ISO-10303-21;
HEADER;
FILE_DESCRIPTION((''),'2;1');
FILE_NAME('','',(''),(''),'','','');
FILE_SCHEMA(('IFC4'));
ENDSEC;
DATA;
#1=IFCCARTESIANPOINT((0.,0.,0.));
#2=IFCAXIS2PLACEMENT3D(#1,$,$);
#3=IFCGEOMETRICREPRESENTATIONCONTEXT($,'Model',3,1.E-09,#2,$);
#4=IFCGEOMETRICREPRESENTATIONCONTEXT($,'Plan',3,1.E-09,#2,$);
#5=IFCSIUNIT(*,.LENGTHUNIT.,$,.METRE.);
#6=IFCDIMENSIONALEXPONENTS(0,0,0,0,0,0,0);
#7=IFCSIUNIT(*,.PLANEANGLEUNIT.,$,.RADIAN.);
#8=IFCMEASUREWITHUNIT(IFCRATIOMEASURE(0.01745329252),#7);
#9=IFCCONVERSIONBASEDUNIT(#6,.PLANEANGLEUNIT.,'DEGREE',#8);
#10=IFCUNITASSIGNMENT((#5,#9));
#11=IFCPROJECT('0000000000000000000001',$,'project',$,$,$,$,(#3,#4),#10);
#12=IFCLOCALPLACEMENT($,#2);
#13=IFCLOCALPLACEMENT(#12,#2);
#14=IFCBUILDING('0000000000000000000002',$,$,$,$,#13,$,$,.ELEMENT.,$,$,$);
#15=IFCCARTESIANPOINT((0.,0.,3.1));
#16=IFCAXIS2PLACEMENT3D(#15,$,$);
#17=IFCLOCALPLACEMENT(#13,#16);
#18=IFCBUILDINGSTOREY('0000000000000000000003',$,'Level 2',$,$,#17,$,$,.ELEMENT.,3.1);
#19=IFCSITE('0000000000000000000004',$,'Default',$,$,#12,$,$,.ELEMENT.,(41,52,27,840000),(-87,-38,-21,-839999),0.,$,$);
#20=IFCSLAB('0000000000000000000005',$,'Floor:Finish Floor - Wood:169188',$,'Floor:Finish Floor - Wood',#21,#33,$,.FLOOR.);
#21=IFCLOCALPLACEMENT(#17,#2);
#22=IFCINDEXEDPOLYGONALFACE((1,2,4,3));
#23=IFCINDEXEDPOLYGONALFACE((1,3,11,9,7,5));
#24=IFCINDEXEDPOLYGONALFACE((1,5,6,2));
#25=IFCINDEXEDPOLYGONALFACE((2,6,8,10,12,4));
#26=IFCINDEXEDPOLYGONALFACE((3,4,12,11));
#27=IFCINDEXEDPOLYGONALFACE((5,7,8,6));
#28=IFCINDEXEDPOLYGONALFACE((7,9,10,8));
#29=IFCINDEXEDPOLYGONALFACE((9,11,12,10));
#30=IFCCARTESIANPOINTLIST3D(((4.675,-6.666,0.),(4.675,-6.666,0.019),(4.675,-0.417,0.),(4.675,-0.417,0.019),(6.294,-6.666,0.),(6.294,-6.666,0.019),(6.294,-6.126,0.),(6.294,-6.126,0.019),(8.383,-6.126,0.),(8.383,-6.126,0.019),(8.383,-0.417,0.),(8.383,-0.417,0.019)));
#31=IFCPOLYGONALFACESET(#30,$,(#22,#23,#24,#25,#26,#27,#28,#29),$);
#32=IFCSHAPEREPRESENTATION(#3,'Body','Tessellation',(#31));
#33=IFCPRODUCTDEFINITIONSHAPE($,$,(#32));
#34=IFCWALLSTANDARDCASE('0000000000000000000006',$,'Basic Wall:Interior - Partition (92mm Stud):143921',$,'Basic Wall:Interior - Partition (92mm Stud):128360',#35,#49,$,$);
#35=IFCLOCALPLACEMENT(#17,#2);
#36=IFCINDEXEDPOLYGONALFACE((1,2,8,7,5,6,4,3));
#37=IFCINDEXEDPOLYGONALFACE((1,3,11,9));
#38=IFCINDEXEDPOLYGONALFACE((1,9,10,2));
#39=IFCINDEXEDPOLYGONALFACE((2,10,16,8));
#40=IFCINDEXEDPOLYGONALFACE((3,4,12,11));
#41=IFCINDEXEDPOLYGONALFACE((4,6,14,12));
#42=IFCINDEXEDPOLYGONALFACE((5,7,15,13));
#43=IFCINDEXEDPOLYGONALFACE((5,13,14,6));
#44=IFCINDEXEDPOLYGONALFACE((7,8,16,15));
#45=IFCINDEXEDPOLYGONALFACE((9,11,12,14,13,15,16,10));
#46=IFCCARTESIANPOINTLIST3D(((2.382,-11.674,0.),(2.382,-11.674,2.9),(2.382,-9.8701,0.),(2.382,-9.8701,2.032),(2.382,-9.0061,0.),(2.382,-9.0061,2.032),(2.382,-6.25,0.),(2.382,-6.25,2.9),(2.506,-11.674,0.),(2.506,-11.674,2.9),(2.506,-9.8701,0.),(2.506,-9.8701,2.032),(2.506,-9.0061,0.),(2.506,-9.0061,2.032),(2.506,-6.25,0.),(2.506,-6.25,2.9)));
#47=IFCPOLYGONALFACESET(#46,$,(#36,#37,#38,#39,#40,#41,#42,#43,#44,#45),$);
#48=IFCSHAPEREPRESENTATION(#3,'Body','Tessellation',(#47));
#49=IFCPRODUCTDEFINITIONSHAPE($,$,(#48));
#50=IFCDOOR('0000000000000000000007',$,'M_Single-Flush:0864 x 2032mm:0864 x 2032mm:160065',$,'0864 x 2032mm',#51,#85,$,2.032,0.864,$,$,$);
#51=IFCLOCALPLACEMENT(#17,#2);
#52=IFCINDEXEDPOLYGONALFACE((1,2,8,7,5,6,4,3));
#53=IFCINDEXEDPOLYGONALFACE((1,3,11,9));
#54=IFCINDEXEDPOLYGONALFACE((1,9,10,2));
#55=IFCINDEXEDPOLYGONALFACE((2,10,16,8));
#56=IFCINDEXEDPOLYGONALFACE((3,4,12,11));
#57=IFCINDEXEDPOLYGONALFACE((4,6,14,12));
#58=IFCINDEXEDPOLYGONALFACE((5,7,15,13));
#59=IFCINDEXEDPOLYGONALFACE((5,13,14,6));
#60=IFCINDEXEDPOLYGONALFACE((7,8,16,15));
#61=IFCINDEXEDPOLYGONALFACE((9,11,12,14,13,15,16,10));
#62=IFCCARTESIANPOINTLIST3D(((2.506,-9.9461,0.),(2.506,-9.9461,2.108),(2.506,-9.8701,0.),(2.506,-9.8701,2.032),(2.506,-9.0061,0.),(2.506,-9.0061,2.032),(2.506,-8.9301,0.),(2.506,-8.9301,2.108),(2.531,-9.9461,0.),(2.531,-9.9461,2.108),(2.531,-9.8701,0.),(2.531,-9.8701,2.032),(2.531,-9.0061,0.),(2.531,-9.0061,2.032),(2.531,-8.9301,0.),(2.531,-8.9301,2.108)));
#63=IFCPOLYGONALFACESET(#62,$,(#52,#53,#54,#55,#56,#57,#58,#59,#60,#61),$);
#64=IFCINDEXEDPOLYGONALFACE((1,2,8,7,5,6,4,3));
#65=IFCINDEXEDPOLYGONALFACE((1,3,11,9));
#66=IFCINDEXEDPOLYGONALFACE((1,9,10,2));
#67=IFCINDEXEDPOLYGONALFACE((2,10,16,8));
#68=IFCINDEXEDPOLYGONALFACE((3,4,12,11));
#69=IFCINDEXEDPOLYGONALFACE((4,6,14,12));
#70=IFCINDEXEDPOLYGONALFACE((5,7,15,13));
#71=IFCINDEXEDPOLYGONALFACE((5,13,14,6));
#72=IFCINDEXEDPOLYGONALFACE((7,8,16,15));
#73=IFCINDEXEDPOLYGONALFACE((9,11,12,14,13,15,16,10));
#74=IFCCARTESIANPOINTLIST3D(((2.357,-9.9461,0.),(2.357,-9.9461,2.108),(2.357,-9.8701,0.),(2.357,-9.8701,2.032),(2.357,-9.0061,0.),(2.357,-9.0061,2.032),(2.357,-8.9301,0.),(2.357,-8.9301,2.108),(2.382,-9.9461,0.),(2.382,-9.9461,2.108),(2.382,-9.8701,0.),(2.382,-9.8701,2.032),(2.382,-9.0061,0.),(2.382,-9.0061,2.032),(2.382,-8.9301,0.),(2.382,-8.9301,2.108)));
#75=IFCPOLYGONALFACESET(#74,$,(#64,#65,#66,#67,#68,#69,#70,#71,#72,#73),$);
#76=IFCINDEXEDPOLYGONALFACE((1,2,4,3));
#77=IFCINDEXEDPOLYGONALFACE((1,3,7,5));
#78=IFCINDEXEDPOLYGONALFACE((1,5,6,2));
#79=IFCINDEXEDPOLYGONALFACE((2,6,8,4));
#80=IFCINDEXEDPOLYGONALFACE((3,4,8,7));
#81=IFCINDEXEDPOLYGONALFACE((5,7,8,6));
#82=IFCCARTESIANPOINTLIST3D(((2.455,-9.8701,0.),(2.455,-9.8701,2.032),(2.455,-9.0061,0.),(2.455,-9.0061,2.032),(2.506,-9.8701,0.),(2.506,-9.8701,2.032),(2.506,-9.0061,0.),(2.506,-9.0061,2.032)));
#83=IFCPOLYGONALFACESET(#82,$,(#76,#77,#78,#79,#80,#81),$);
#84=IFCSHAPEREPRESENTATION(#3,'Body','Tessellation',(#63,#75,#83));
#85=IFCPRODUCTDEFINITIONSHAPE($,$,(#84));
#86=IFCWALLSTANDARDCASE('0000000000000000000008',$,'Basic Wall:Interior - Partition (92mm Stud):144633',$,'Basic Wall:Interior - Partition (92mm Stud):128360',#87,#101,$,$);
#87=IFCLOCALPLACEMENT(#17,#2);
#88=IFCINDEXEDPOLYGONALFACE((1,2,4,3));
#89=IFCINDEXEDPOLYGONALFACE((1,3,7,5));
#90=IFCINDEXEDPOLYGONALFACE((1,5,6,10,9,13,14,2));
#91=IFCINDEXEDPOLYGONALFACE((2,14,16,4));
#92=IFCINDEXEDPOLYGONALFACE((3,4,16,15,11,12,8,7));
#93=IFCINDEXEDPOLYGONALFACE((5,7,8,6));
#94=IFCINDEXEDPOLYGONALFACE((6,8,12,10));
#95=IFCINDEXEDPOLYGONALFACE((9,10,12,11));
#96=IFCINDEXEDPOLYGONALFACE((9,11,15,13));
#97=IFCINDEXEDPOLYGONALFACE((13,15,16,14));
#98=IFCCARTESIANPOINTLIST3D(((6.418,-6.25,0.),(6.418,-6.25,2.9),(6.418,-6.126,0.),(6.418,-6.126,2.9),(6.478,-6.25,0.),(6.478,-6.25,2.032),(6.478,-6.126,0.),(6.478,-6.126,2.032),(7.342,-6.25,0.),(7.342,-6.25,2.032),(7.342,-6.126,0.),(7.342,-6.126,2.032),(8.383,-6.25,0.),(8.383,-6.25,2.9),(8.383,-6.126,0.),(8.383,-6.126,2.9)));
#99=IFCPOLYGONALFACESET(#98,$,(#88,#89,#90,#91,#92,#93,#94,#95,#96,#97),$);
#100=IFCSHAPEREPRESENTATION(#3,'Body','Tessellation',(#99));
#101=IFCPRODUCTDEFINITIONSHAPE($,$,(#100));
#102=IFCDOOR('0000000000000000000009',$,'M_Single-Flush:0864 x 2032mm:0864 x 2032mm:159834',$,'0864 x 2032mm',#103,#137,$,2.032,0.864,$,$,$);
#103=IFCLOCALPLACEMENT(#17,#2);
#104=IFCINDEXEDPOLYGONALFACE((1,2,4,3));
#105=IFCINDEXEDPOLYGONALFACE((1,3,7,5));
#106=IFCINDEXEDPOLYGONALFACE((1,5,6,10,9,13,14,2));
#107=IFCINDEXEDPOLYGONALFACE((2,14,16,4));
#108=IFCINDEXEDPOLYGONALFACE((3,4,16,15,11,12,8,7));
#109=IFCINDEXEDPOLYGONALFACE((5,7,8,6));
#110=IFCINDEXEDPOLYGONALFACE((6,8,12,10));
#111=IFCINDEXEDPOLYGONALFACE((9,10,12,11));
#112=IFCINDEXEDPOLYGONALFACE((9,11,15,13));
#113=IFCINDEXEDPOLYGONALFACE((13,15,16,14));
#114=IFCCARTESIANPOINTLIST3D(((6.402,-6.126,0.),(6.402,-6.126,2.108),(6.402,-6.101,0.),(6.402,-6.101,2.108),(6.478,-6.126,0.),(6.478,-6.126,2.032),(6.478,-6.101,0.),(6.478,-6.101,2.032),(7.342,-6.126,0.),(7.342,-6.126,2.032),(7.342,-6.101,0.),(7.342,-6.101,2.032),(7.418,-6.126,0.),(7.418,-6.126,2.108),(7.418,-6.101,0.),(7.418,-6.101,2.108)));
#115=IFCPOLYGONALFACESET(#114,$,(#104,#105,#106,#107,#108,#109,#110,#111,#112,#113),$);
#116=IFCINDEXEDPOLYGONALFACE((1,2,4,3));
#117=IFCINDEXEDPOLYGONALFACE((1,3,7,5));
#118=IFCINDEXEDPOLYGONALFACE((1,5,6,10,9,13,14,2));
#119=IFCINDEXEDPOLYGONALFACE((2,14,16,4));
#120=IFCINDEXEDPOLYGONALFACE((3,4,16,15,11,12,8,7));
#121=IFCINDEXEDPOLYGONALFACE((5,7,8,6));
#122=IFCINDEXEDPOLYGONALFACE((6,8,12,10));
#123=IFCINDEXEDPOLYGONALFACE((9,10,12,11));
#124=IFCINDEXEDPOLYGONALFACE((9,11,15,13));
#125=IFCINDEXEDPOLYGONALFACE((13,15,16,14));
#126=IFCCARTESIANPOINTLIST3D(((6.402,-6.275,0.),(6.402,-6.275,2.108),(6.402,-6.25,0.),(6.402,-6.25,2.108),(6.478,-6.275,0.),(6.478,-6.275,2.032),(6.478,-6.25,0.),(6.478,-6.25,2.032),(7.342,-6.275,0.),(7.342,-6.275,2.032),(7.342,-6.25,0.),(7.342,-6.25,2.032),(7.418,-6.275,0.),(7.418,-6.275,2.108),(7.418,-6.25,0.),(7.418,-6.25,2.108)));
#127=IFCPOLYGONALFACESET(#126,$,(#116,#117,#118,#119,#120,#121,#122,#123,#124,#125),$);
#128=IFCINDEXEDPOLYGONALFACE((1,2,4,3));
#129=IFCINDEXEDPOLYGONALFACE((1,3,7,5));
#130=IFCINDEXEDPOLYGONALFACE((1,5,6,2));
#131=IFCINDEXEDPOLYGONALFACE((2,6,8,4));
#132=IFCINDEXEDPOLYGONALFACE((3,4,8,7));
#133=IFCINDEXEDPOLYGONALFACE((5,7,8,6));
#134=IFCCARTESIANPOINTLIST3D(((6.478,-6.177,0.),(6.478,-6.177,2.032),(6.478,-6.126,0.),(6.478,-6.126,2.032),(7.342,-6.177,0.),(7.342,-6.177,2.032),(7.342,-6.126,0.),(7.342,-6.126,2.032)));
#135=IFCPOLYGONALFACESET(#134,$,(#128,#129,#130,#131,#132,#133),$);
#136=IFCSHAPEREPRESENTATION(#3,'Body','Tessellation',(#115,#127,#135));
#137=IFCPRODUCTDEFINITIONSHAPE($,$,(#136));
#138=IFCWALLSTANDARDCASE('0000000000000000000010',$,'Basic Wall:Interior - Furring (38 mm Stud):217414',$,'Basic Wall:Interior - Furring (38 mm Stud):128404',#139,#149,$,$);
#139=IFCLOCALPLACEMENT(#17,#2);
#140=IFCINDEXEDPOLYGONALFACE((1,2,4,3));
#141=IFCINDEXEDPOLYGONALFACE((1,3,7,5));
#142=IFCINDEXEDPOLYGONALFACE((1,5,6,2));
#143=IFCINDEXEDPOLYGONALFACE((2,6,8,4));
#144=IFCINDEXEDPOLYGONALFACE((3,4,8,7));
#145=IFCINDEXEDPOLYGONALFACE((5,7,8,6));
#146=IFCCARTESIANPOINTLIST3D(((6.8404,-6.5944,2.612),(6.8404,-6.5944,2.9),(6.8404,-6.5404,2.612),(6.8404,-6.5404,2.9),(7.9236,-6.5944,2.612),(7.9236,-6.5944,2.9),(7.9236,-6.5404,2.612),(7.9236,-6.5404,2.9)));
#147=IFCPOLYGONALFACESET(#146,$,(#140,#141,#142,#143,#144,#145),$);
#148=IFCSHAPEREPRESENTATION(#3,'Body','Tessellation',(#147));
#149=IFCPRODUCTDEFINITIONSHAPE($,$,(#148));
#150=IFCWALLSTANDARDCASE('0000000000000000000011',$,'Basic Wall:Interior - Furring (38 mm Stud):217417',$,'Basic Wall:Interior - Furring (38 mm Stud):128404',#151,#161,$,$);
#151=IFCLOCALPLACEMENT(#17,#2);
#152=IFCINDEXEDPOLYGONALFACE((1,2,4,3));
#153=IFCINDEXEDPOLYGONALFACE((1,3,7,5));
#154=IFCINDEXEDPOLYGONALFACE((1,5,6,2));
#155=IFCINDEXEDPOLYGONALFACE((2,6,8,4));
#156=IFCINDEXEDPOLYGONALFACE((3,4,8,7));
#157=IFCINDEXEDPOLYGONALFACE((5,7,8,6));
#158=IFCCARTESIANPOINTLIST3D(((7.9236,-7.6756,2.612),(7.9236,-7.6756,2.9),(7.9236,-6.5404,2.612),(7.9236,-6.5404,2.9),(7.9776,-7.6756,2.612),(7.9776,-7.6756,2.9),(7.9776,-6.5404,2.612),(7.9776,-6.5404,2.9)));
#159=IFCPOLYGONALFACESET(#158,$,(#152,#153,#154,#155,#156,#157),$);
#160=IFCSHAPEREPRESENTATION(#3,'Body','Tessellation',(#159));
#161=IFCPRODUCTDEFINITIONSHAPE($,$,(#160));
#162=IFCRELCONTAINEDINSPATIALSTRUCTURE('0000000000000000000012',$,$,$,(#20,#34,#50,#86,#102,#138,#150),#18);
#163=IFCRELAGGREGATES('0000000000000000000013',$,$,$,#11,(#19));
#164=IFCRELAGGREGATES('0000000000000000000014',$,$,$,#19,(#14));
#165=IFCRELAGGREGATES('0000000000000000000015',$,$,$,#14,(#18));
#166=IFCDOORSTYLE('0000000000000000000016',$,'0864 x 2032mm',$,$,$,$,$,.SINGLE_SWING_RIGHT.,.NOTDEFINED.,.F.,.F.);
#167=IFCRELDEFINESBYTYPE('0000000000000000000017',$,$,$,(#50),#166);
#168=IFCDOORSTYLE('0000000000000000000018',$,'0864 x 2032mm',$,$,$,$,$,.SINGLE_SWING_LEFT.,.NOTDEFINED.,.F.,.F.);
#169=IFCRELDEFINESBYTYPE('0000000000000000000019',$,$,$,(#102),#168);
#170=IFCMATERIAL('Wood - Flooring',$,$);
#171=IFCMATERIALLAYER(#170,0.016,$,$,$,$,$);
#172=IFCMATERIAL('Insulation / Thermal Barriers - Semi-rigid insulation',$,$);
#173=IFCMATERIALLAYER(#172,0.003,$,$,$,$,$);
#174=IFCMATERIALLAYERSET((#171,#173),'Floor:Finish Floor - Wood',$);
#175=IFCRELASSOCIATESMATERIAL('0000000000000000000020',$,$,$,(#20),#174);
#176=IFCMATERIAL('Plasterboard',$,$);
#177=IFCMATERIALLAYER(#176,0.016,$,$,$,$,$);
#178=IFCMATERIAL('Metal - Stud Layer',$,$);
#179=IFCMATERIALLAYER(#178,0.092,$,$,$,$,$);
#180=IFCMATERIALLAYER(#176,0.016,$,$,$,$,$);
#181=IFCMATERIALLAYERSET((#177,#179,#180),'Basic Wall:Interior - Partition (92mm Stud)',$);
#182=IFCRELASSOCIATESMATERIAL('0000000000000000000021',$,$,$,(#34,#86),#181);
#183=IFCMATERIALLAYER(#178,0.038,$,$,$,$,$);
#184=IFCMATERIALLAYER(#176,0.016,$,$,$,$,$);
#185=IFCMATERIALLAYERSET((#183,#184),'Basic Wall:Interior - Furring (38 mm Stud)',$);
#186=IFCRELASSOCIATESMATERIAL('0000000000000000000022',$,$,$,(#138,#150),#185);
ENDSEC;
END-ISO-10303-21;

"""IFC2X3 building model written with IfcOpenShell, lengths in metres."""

from ifc_helpers import new_model, entity, si_unit, converted_unit, frame, frame_2d, origin, origin_2d_with_axis, place, context, project, spatial, polyline, rectangle, outline, extrude, source, transform, mapped, material, layer, layer_set, layer_usage, type_object, type_shapes, element, fill, save


model = new_model("IFC2X3")

# Units and contexts
model_context = context("Model", 3, precision=1e-09, world=origin())
plan_context = context("Plan", 3, precision=1e-09, world=origin())
ifc_project = project(units=[si_unit("LENGTHUNIT", "METRE"), converted_unit("PLANEANGLEUNIT", "DEGREE", entity("IfcRatioMeasure", 0.01745329252), si_unit("PLANEANGLEUNIT", "RADIAN"), dimensions=[0, 0, 0, 0, 0, 0, 0])], contexts=[model_context, plan_context])

# Site, building, storey
site_placement = place(None, origin())
site = spatial("IfcSite", under=ifc_project, at=site_placement, Name="Default", CompositionType="ELEMENT", RefLatitude=(41, 52, 27, 840000), RefLongitude=(-87, -38, -21, -839999), RefElevation=0.0)
building_placement = place(site_placement, origin())
building = spatial("IfcBuilding", under=site, at=building_placement, CompositionType="ELEMENT")
storey_placement = place(building_placement, frame((0.0, 0.0, 3.1)))
storey = spatial("IfcBuildingStorey", under=building, at=storey_placement, Name="Level 2", CompositionType="ELEMENT", Elevation=3.1)

# Slab
ifc_material_1 = material(Name="Wood - Flooring")
ifc_layer_1 = layer(ifc_material_1, 0.016)
ifc_material_2 = material(Name="Insulation / Thermal Barriers - Semi-rigid insulation")
ifc_layer_2 = layer(ifc_material_2, 0.003)
ifc_layer_set_1 = layer_set([ifc_layer_1, ifc_layer_2], Name="Floor:Finish Floor - Wood")
ifc_layer_usage_1 = layer_usage(ifc_layer_set_1, "AXIS3", "POSITIVE", 0.0)
slab_placement = place(storey_placement, frame((4.675, -6.666, 0.0)))
element("IfcSlab", 1, at=slab_placement, inside=storey, material=ifc_layer_usage_1, Name="Floor:Finish Floor - Wood:169188", ObjectType="Floor:Finish Floor - Wood", PredefinedType="FLOOR", context=model_context, shape_type="SweptSolid", body=[
    extrude(outline(polyline([(-1.854, 3.1245), (-1.854, -2.5845), (0.235, -2.5845), (0.235, -3.1245), (1.854, -3.1245), (1.854, 3.1245), (-1.854, 3.1245)])), frame((1.854, 3.1245, 0.019), z_axis=(0.0, 0.0, -1.0), x_axis=(-1.0, 0.0, 0.0)), (0.0, 0.0, 1.0), 0.019),
])

# Shared definitions
ifc_material_3 = material(Name="Metal - Stud Layer")
ifc_material_4 = material(Name="Plasterboard")

# Walls, openings, doors
ifc_layer_3 = layer(ifc_material_4, 0.016)
ifc_layer_4 = layer(ifc_material_3, 0.092)
ifc_layer_5 = layer(ifc_material_4, 0.016)
ifc_layer_set_2 = layer_set([ifc_layer_3, ifc_layer_4, ifc_layer_5], Name="Basic Wall:Interior - Partition (92mm Stud)")
ifc_layer_usage_2 = layer_usage(ifc_layer_set_2, "AXIS2", "NEGATIVE", 0.062)
wall_1_placement = place(storey_placement, frame((2.444, -6.25, 0.0), z_axis=(0.0, 0.0, 1.0), x_axis=(0.0, -1.0, 0.0)))
wall_1 = element("IfcWallStandardCase", 2, at=wall_1_placement, inside=storey, material=ifc_layer_usage_2, Name="Basic Wall:Interior - Partition (92mm Stud):143921", ObjectType="Basic Wall:Interior - Partition (92mm Stud):128360", context=model_context, shape_type="SweptSolid", body=[
    extrude(rectangle(XDim=5.424, YDim=0.124, at=frame_2d((2.712, 0.0), x_axis=(-1.0, 0.0))), origin(), (0.0, 0.0, 1.0), 2.9),
])
opening_1_placement = place(wall_1_placement, frame((2.7561, -0.062, 0.0)))
opening_1 = element("IfcOpeningElement", 3, at=opening_1_placement, cuts=wall_1, ObjectType="Opening", context=model_context, shape_type="SweptSolid", body=[
    extrude(rectangle(XDim=0.864, YDim=2.032, at=frame_2d((1.016, 0.432), x_axis=(0.0, 1.0))), frame((0.0, 0.0, 0.0), z_axis=(0.0, 1.0, 0.0), x_axis=(0.0, 0.0, 1.0)), (0.0, 0.0, 1.0), 0.124),
])
door_style_1 = type_object("IfcDoorStyle", Name="0864 x 2032mm", ConstructionType="NOTDEFINED", OperationType="SINGLE_SWING_RIGHT", ParameterTakesPrecedence=False, Sizeable=False)
shared_shape_1 = source(origin(), model_context, "Body", "SweptSolid", [
    extrude(outline(polyline([(-0.508, -1.073), (0.508, -1.073), (0.508, 1.035), (0.432, 1.035), (0.432, -0.997), (-0.432, -0.997), (-0.432, 1.035), (-0.508, 1.035), (-0.508, -1.073)])), frame((0.432, 0.124, 1.035), z_axis=(0.0, 1.0, 0.0), x_axis=(1.0, 0.0, 0.0)), (0.0, 0.0, 1.0), 0.025),
    extrude(outline(polyline([(-1.073, -0.508), (1.035, -0.508), (1.035, -0.432), (-0.997, -0.432), (-0.997, 0.432), (1.035, 0.432), (1.035, 0.508), (-1.073, 0.508), (-1.073, -0.508)])), frame((0.432, -0.025, 1.035), z_axis=(0.0, 1.0, 0.0), x_axis=(0.0, 0.0, -1.0)), (0.0, 0.0, 1.0), 0.025),
    extrude(rectangle(XDim=0.051, YDim=0.864, at=origin_2d_with_axis()), frame((0.432, 0.0985, 0.0), z_axis=(0.0, 0.0, 1.0), x_axis=(0.0, 1.0, 0.0)), (0.0, 0.0, 1.0), 2.032),
])
type_shapes(door_style_1, [shared_shape_1])
door_1_placement = place(opening_1_placement, origin())
door_1 = element("IfcDoor", 4, at=door_1_placement, inside=storey, type_object=door_style_1, Name="M_Single-Flush:0864 x 2032mm:0864 x 2032mm:160065", ObjectType="0864 x 2032mm", OverallHeight=2.032, OverallWidth=0.864, context=model_context, shape_type="MappedRepresentation", body=[
    mapped(shared_shape_1, transform((0.0, 0.0, 0.0), scale=1.0)),
])
fill(opening_1, door_1)
ifc_layer_usage_3 = layer_usage(ifc_layer_set_2, "AXIS2", "NEGATIVE", 0.062)
wall_2_placement = place(storey_placement, frame((6.418, -6.188, 0.0)))
wall_2 = element("IfcWallStandardCase", 5, at=wall_2_placement, inside=storey, material=ifc_layer_usage_3, Name="Basic Wall:Interior - Partition (92mm Stud):144633", ObjectType="Basic Wall:Interior - Partition (92mm Stud):128360", context=model_context, shape_type="SweptSolid", body=[
    extrude(rectangle(XDim=1.965, YDim=0.124, at=frame_2d((0.9825, 0.0), x_axis=(-1.0, 0.0))), origin(), (0.0, 0.0, 1.0), 2.9),
])
opening_2_placement = place(wall_2_placement, frame((0.06, -0.062, 0.0)))
opening_2 = element("IfcOpeningElement", 6, at=opening_2_placement, cuts=wall_2, ObjectType="Opening", context=model_context, shape_type="SweptSolid", body=[
    extrude(rectangle(XDim=0.864, YDim=2.032, at=frame_2d((1.016, 0.432), x_axis=(0.0, -1.0))), frame((0.0, 0.0, 0.0), z_axis=(0.0, 1.0, 0.0), x_axis=(0.0, 0.0, 1.0)), (0.0, 0.0, 1.0), 0.124),
])
door_style_2 = type_object("IfcDoorStyle", Name="0864 x 2032mm", ConstructionType="NOTDEFINED", OperationType="SINGLE_SWING_LEFT", ParameterTakesPrecedence=False, Sizeable=False)
shared_shape_2 = source(origin(), model_context, "Body", "SweptSolid", [
    extrude(outline(polyline([(-0.508, -1.073), (0.508, -1.073), (0.508, 1.035), (0.432, 1.035), (0.432, -0.997), (-0.432, -0.997), (-0.432, 1.035), (-0.508, 1.035), (-0.508, -1.073)])), frame((0.432, 0.149, 1.035), z_axis=(0.0, -1.0, 0.0), x_axis=(-1.0, 0.0, 0.0)), (0.0, 0.0, 1.0), 0.025),
    extrude(outline(polyline([(-1.073, -0.508), (1.035, -0.508), (1.035, -0.432), (-0.997, -0.432), (-0.997, 0.432), (1.035, 0.432), (1.035, 0.508), (-1.073, 0.508), (-1.073, -0.508)])), frame((0.432, 0.0, 1.035), z_axis=(0.0, -1.0, 0.0), x_axis=(0.0, 0.0, -1.0)), (0.0, 0.0, 1.0), 0.025),
    extrude(rectangle(XDim=0.864, YDim=0.051, at=origin_2d_with_axis()), frame((0.432, 0.0985, 0.0)), (0.0, 0.0, 1.0), 2.032),
])
type_shapes(door_style_2, [shared_shape_2])
door_2_placement = place(opening_2_placement, origin())
door_2 = element("IfcDoor", 7, at=door_2_placement, inside=storey, type_object=door_style_2, Name="M_Single-Flush:0864 x 2032mm:0864 x 2032mm:159834", ObjectType="0864 x 2032mm", OverallHeight=2.032, OverallWidth=0.864, context=model_context, shape_type="MappedRepresentation", body=[
    mapped(shared_shape_2, transform((0.0, 0.0, 0.0), scale=1.0)),
])
fill(opening_2, door_2)

# Walls
ifc_layer_6 = layer(ifc_material_3, 0.038)
ifc_layer_7 = layer(ifc_material_4, 0.016)
ifc_layer_set_3 = layer_set([ifc_layer_6, ifc_layer_7], Name="Basic Wall:Interior - Furring (38 mm Stud)")
ifc_layer_usage_4 = layer_usage(ifc_layer_set_3, "AXIS2", "NEGATIVE", 0.027)
wall_3_placement = place(storey_placement, frame((6.8404, -6.5675, 2.612)))
element("IfcWallStandardCase", 8, at=wall_3_placement, inside=storey, material=ifc_layer_usage_4, Name="Basic Wall:Interior - Furring (38 mm Stud):217414", ObjectType="Basic Wall:Interior - Furring (38 mm Stud):128404", context=model_context, shape_type="SweptSolid", body=[
    extrude(rectangle(XDim=1.0831, YDim=0.054, at=frame_2d((0.5415, 0.0), x_axis=(-1.0, 0.0))), origin(), (0.0, 0.0, 1.0), 0.288),
])
ifc_layer_usage_5 = layer_usage(ifc_layer_set_3, "AXIS2", "NEGATIVE", 0.027)
wall_4_placement = place(storey_placement, frame((7.9505, -6.5404, 2.612), z_axis=(0.0, 0.0, 1.0), x_axis=(0.0, -1.0, 0.0)))
element("IfcWallStandardCase", 9, at=wall_4_placement, inside=storey, material=ifc_layer_usage_5, Name="Basic Wall:Interior - Furring (38 mm Stud):217417", ObjectType="Basic Wall:Interior - Furring (38 mm Stud):128404", context=model_context, shape_type="SweptSolid", body=[
    extrude(rectangle(XDim=1.1351, YDim=0.054, at=frame_2d((0.5675, 0.0), x_axis=(-1.0, 0.0))), origin(), (0.0, 0.0, 1.0), 0.288),
])

save(model, "model.ifc")
